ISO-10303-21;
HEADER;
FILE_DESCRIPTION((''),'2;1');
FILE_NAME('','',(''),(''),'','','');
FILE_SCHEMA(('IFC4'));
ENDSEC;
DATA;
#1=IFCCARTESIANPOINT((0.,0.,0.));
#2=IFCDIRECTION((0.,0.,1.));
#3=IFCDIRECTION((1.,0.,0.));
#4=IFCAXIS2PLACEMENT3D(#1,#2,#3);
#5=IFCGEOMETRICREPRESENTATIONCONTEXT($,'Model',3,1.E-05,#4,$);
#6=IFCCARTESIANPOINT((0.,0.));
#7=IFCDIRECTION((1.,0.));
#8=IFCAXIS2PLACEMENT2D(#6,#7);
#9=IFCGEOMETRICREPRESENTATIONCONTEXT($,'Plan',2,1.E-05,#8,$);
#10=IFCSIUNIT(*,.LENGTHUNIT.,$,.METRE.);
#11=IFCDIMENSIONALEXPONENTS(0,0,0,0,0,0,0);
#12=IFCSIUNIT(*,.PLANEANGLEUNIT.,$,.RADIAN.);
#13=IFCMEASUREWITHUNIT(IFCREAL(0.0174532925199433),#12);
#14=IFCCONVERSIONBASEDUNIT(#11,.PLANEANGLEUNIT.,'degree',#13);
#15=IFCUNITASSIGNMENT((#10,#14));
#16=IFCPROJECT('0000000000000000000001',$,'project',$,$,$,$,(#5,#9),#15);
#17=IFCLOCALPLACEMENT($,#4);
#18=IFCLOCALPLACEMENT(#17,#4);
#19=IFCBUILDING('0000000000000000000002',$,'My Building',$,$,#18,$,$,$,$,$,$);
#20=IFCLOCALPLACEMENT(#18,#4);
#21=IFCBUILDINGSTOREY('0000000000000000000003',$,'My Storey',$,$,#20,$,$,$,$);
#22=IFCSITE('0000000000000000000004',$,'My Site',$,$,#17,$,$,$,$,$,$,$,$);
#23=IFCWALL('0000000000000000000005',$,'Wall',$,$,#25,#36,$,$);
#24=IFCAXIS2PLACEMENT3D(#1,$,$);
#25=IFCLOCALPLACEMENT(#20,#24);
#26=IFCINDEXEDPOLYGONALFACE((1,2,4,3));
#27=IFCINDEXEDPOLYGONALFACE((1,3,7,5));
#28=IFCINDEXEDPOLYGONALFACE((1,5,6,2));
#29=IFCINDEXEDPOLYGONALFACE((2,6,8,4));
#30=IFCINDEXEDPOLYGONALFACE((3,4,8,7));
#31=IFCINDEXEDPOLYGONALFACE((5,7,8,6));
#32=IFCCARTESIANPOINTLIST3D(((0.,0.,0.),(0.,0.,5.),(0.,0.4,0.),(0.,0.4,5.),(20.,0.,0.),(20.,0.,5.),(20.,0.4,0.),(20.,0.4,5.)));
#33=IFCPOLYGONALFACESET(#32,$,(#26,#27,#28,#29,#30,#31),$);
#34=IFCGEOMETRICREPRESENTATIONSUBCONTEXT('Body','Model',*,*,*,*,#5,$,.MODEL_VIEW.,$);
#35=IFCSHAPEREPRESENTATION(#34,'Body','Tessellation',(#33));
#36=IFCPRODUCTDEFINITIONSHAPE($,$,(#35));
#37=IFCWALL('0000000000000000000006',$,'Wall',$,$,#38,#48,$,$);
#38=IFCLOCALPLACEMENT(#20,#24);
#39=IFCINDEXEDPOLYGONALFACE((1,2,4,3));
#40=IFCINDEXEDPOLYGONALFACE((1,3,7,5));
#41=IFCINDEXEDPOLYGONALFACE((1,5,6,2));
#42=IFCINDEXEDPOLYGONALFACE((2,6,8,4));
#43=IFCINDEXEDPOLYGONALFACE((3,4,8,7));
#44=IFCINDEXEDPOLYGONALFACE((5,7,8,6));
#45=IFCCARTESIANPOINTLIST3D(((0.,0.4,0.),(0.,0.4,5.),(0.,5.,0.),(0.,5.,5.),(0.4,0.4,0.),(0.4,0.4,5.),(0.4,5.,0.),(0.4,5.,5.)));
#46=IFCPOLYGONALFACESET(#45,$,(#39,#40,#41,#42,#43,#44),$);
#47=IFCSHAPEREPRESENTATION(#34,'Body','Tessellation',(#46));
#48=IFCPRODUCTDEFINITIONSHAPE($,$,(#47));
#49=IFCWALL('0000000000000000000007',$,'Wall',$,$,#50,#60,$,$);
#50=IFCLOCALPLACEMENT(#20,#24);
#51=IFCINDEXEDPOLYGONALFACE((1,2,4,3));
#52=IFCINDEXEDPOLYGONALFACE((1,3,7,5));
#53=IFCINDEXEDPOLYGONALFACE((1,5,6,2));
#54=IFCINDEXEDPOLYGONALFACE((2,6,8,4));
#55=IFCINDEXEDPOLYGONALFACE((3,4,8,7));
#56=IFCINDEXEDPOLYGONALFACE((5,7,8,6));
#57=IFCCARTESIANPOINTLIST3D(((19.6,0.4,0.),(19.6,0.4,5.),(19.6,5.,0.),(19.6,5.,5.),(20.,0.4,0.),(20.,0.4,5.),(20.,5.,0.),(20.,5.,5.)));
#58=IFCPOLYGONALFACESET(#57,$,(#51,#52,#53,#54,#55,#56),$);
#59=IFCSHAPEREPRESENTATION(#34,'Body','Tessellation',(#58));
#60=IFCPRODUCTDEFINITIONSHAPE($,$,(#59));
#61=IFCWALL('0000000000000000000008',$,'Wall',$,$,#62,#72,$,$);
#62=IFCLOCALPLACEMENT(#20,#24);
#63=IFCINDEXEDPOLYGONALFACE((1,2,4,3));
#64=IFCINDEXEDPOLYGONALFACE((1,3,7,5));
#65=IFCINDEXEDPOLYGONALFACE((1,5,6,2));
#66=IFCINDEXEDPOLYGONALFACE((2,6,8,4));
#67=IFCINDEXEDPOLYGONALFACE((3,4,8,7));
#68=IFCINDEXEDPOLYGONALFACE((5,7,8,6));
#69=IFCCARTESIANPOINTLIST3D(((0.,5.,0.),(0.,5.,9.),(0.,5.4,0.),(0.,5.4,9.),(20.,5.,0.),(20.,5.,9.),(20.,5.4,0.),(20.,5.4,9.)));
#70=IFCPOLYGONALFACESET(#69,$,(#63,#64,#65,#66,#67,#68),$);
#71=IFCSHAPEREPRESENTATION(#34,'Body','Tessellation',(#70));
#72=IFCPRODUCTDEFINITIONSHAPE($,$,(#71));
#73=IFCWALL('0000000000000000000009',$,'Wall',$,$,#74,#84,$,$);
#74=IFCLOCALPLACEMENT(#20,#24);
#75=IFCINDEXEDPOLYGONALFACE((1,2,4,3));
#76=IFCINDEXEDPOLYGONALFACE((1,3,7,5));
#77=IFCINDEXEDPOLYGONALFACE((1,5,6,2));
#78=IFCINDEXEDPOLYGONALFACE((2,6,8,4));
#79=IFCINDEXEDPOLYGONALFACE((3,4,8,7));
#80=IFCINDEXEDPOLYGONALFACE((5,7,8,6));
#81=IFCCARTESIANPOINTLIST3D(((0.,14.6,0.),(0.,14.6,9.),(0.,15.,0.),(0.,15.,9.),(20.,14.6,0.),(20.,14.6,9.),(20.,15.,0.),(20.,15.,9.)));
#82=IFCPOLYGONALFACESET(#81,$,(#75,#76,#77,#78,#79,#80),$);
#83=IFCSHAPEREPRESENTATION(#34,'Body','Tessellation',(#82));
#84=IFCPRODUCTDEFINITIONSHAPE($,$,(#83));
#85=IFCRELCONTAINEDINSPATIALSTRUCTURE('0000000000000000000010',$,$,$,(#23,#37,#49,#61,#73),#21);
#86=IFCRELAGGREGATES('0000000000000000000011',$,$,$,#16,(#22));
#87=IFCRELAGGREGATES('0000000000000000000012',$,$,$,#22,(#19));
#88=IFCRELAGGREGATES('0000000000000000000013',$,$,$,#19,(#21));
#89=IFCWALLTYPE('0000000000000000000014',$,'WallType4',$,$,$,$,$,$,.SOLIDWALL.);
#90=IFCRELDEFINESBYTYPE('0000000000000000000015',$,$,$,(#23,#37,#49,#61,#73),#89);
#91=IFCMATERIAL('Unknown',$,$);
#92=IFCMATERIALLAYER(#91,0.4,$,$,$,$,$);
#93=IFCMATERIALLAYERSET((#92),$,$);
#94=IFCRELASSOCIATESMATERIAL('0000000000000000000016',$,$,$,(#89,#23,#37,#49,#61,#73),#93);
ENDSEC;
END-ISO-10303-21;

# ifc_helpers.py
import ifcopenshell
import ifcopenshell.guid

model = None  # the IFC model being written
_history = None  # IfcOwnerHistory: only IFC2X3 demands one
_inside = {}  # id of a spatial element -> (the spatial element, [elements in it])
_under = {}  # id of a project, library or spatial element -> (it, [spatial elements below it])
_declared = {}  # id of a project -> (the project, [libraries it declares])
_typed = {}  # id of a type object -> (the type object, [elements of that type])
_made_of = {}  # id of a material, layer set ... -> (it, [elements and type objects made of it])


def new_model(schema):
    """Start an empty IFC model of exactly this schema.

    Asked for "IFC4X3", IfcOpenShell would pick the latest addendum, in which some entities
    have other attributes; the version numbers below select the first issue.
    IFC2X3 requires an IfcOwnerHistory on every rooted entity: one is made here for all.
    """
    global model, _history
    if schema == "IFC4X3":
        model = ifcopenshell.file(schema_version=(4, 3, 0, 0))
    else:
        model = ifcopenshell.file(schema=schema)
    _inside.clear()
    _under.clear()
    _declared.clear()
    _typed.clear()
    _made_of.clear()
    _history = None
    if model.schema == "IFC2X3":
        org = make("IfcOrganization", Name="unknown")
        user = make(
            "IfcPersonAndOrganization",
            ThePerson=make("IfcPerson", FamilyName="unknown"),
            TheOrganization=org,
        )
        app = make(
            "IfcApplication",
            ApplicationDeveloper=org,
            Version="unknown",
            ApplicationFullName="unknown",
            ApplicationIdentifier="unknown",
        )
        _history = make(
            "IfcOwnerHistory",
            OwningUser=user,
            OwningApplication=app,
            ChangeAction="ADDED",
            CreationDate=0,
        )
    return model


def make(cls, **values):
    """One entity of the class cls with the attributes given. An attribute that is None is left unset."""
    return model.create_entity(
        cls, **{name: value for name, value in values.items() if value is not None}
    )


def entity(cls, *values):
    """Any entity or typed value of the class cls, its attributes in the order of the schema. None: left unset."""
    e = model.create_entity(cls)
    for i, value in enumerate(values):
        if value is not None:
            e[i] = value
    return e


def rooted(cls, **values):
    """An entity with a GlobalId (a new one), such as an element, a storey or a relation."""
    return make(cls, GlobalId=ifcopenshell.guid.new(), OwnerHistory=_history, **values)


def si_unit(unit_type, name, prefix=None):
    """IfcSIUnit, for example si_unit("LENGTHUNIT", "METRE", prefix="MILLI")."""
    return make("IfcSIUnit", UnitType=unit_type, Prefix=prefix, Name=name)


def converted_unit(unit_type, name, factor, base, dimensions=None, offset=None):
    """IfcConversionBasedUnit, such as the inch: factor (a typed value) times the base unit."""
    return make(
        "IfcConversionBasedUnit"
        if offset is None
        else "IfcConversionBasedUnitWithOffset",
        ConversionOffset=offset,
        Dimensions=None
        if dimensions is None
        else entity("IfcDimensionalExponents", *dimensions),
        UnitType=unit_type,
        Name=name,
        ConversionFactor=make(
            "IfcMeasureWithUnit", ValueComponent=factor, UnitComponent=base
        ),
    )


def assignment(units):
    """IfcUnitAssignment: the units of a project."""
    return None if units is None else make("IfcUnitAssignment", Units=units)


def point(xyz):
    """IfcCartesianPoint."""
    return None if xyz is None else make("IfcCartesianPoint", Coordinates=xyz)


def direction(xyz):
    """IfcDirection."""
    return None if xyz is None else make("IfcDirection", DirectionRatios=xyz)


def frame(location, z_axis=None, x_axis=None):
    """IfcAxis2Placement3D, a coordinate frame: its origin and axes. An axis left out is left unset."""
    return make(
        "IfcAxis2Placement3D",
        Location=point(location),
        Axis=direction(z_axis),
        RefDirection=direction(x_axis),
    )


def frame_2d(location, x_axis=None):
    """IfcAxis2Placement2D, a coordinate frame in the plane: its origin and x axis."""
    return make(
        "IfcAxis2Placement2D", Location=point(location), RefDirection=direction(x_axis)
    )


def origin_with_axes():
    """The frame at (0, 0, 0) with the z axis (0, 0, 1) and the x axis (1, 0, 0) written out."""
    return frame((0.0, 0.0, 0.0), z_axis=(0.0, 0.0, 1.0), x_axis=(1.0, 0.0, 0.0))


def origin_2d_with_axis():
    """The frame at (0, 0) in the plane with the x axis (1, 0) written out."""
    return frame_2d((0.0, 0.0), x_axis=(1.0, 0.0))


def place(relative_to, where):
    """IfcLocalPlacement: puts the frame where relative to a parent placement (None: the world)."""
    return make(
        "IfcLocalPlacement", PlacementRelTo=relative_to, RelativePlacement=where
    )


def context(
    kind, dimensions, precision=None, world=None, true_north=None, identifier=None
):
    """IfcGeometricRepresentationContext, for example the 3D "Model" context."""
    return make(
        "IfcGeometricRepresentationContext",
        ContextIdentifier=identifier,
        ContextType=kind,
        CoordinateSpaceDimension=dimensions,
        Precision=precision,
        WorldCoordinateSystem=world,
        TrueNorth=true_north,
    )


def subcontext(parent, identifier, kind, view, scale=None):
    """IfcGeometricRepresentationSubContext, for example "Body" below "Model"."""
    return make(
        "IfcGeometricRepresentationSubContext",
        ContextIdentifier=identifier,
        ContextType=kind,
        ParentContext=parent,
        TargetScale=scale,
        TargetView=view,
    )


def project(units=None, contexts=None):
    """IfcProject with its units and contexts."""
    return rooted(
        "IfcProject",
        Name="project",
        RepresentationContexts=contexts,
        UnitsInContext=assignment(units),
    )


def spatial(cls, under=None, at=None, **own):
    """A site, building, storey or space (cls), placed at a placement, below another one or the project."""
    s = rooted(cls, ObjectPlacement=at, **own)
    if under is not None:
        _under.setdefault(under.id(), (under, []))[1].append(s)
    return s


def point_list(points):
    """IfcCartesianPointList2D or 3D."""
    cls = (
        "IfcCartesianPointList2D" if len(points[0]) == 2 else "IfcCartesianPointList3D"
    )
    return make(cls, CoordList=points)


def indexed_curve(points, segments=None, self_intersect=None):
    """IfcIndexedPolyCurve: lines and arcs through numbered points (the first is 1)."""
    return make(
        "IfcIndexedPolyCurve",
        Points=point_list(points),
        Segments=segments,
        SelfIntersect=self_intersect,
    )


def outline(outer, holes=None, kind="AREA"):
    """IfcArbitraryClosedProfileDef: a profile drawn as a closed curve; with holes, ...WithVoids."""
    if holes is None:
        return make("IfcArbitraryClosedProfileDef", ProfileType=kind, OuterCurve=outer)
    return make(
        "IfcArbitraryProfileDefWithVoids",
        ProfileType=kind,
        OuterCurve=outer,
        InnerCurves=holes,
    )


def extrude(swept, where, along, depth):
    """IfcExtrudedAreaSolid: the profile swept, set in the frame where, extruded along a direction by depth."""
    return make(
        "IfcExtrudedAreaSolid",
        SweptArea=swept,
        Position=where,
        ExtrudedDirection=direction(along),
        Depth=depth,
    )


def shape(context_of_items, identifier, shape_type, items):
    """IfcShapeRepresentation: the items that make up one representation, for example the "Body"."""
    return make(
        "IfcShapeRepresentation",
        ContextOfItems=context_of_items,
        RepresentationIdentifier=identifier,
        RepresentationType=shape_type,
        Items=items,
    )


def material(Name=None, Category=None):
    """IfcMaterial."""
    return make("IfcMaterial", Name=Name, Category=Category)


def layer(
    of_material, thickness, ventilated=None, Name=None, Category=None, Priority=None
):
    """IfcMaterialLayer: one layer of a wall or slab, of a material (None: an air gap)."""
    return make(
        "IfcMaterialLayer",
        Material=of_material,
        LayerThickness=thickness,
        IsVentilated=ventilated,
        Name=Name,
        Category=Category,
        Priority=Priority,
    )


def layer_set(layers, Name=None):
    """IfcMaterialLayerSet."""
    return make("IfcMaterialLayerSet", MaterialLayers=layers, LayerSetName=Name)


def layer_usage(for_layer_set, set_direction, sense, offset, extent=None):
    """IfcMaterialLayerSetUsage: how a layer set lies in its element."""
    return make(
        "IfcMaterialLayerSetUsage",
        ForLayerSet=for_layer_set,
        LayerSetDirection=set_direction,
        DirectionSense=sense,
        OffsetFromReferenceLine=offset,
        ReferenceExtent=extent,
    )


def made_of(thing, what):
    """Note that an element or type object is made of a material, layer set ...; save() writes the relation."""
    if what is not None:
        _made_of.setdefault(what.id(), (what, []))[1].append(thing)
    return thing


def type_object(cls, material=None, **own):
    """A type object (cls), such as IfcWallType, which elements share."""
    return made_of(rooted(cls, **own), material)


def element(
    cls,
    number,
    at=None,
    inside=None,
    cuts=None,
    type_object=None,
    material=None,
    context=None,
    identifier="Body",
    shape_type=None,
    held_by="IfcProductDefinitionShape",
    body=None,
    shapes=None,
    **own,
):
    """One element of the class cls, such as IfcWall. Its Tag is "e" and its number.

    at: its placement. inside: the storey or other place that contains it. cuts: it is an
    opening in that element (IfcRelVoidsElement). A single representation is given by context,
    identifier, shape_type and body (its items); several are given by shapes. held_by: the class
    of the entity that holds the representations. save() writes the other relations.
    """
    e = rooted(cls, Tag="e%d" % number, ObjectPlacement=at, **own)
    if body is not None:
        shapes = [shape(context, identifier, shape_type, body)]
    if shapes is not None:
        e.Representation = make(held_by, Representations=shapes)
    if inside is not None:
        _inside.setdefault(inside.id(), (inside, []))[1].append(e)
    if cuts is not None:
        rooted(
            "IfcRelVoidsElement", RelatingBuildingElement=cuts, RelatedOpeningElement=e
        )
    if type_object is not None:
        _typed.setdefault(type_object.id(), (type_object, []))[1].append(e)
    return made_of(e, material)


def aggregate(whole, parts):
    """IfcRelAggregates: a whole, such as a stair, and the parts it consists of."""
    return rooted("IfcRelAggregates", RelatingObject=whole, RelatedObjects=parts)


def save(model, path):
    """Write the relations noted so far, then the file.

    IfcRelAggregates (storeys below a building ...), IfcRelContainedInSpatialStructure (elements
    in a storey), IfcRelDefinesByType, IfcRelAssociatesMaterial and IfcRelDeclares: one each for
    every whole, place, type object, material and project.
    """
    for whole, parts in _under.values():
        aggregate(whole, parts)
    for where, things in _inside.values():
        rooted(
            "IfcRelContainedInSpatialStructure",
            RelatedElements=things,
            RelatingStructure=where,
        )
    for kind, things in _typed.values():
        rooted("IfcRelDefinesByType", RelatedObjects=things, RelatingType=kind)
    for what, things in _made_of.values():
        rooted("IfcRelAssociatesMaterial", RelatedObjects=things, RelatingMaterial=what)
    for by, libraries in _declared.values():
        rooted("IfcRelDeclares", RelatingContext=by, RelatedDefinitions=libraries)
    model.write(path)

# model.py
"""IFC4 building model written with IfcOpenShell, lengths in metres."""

from ifc_helpers import new_model, entity, si_unit, converted_unit, frame, origin_with_axes, origin_2d_with_axis, place, context, subcontext, project, spatial, indexed_curve, outline, extrude, material, layer, layer_set, layer_usage, type_object, element, save


model = new_model("IFC4")

# Units and contexts
model_context = context("Model", 3, precision=1e-05, world=origin_with_axes())
plan_context = context("Plan", 2, precision=1e-05, world=origin_2d_with_axis())
body_context_1 = subcontext(model_context, "Body", "Model", "MODEL_VIEW")
ifc_project = project(units=[si_unit("LENGTHUNIT", "METRE"), converted_unit("PLANEANGLEUNIT", "degree", entity("IfcReal", 0.0174532925199433), si_unit("PLANEANGLEUNIT", "RADIAN"), dimensions=[0, 0, 0, 0, 0, 0, 0])], contexts=[model_context, plan_context])

# Site, building, storey
site_placement = place(None, origin_with_axes())
site = spatial("IfcSite", under=ifc_project, at=site_placement, Name="My Site")
building_placement = place(site_placement, origin_with_axes())
building = spatial("IfcBuilding", under=site, at=building_placement, Name="My Building")
storey_placement = place(building_placement, origin_with_axes())
storey = spatial("IfcBuildingStorey", under=building, at=storey_placement, Name="My Storey")

# Walls
ifc_material = material(Name="Unknown")
ifc_layer = layer(ifc_material, 0.4)
ifc_layer_set = layer_set([ifc_layer])
ifc_layer_usage_1 = layer_usage(ifc_layer_set, "AXIS2", "POSITIVE", 0.0)
wall_type = type_object("IfcWallType", Name="WallType4", PredefinedType="SOLIDWALL", material=ifc_layer_set)
wall_1_placement = place(storey_placement, origin_with_axes())
element("IfcWall", 1, at=wall_1_placement, inside=storey, type_object=wall_type, material=ifc_layer_usage_1, Name="Wall", context=body_context_1, shape_type="SweptSolid", body=[
    extrude(outline(indexed_curve([(0.0, 0.0), (0.0, 0.4), (20.0, 0.4), (20.0, 0.0), (0.0, 0.0)], self_intersect=False)), origin_with_axes(), (0.0, 0.0, 1.0), 5.0),
])
ifc_layer_usage_2 = layer_usage(ifc_layer_set, "AXIS2", "POSITIVE", 0.0)
wall_2_placement = place(storey_placement, frame((0.4, 0.4, 0.0), z_axis=(0.0, 0.0, 1.0), x_axis=(0.0, 1.0, 0.0)))
element("IfcWall", 2, at=wall_2_placement, inside=storey, type_object=wall_type, material=ifc_layer_usage_2, Name="Wall", context=body_context_1, shape_type="SweptSolid", body=[
    extrude(outline(indexed_curve([(0.0, 0.0), (0.0, 0.4), (4.6, 0.4), (4.6, 0.0), (0.0, 0.0)], self_intersect=False)), origin_with_axes(), (0.0, 0.0, 1.0), 5.0),
])
ifc_layer_usage_3 = layer_usage(ifc_layer_set, "AXIS2", "POSITIVE", 0.0)
wall_3_placement = place(storey_placement, frame((20.0, 0.4, 0.0), z_axis=(0.0, 0.0, 1.0), x_axis=(0.0, 1.0, 0.0)))
element("IfcWall", 3, at=wall_3_placement, inside=storey, type_object=wall_type, material=ifc_layer_usage_3, Name="Wall", context=body_context_1, shape_type="SweptSolid", body=[
    extrude(outline(indexed_curve([(0.0, 0.0), (0.0, 0.4), (4.6, 0.4), (4.6, 0.0), (0.0, 0.0)], self_intersect=False)), origin_with_axes(), (0.0, 0.0, 1.0), 5.0),
])
ifc_layer_usage_4 = layer_usage(ifc_layer_set, "AXIS2", "POSITIVE", 0.0)
wall_4_placement = place(storey_placement, frame((0.0, 5.0, 0.0), z_axis=(0.0, 0.0, 1.0), x_axis=(1.0, 0.0, 0.0)))
element("IfcWall", 4, at=wall_4_placement, inside=storey, type_object=wall_type, material=ifc_layer_usage_4, Name="Wall", context=body_context_1, shape_type="SweptSolid", body=[
    extrude(outline(indexed_curve([(0.0, 0.0), (0.0, 0.4), (20.0, 0.4), (20.0, 0.0), (0.0, 0.0)], self_intersect=False)), origin_with_axes(), (0.0, 0.0, 1.0), 9.0),
])
ifc_layer_usage_5 = layer_usage(ifc_layer_set, "AXIS2", "POSITIVE", 0.0)
wall_5_placement = place(storey_placement, frame((0.0, 14.6, 0.0), z_axis=(0.0, 0.0, 1.0), x_axis=(1.0, 0.0, 0.0)))
element("IfcWall", 5, at=wall_5_placement, inside=storey, type_object=wall_type, material=ifc_layer_usage_5, Name="Wall", context=body_context_1, shape_type="SweptSolid", body=[
    extrude(outline(indexed_curve([(0.0, 0.0), (0.0, 0.4), (20.0, 0.4), (20.0, 0.0), (0.0, 0.0)], self_intersect=False)), origin_with_axes(), (0.0, 0.0, 1.0), 9.0),
])

save(model, "model.ifc")
